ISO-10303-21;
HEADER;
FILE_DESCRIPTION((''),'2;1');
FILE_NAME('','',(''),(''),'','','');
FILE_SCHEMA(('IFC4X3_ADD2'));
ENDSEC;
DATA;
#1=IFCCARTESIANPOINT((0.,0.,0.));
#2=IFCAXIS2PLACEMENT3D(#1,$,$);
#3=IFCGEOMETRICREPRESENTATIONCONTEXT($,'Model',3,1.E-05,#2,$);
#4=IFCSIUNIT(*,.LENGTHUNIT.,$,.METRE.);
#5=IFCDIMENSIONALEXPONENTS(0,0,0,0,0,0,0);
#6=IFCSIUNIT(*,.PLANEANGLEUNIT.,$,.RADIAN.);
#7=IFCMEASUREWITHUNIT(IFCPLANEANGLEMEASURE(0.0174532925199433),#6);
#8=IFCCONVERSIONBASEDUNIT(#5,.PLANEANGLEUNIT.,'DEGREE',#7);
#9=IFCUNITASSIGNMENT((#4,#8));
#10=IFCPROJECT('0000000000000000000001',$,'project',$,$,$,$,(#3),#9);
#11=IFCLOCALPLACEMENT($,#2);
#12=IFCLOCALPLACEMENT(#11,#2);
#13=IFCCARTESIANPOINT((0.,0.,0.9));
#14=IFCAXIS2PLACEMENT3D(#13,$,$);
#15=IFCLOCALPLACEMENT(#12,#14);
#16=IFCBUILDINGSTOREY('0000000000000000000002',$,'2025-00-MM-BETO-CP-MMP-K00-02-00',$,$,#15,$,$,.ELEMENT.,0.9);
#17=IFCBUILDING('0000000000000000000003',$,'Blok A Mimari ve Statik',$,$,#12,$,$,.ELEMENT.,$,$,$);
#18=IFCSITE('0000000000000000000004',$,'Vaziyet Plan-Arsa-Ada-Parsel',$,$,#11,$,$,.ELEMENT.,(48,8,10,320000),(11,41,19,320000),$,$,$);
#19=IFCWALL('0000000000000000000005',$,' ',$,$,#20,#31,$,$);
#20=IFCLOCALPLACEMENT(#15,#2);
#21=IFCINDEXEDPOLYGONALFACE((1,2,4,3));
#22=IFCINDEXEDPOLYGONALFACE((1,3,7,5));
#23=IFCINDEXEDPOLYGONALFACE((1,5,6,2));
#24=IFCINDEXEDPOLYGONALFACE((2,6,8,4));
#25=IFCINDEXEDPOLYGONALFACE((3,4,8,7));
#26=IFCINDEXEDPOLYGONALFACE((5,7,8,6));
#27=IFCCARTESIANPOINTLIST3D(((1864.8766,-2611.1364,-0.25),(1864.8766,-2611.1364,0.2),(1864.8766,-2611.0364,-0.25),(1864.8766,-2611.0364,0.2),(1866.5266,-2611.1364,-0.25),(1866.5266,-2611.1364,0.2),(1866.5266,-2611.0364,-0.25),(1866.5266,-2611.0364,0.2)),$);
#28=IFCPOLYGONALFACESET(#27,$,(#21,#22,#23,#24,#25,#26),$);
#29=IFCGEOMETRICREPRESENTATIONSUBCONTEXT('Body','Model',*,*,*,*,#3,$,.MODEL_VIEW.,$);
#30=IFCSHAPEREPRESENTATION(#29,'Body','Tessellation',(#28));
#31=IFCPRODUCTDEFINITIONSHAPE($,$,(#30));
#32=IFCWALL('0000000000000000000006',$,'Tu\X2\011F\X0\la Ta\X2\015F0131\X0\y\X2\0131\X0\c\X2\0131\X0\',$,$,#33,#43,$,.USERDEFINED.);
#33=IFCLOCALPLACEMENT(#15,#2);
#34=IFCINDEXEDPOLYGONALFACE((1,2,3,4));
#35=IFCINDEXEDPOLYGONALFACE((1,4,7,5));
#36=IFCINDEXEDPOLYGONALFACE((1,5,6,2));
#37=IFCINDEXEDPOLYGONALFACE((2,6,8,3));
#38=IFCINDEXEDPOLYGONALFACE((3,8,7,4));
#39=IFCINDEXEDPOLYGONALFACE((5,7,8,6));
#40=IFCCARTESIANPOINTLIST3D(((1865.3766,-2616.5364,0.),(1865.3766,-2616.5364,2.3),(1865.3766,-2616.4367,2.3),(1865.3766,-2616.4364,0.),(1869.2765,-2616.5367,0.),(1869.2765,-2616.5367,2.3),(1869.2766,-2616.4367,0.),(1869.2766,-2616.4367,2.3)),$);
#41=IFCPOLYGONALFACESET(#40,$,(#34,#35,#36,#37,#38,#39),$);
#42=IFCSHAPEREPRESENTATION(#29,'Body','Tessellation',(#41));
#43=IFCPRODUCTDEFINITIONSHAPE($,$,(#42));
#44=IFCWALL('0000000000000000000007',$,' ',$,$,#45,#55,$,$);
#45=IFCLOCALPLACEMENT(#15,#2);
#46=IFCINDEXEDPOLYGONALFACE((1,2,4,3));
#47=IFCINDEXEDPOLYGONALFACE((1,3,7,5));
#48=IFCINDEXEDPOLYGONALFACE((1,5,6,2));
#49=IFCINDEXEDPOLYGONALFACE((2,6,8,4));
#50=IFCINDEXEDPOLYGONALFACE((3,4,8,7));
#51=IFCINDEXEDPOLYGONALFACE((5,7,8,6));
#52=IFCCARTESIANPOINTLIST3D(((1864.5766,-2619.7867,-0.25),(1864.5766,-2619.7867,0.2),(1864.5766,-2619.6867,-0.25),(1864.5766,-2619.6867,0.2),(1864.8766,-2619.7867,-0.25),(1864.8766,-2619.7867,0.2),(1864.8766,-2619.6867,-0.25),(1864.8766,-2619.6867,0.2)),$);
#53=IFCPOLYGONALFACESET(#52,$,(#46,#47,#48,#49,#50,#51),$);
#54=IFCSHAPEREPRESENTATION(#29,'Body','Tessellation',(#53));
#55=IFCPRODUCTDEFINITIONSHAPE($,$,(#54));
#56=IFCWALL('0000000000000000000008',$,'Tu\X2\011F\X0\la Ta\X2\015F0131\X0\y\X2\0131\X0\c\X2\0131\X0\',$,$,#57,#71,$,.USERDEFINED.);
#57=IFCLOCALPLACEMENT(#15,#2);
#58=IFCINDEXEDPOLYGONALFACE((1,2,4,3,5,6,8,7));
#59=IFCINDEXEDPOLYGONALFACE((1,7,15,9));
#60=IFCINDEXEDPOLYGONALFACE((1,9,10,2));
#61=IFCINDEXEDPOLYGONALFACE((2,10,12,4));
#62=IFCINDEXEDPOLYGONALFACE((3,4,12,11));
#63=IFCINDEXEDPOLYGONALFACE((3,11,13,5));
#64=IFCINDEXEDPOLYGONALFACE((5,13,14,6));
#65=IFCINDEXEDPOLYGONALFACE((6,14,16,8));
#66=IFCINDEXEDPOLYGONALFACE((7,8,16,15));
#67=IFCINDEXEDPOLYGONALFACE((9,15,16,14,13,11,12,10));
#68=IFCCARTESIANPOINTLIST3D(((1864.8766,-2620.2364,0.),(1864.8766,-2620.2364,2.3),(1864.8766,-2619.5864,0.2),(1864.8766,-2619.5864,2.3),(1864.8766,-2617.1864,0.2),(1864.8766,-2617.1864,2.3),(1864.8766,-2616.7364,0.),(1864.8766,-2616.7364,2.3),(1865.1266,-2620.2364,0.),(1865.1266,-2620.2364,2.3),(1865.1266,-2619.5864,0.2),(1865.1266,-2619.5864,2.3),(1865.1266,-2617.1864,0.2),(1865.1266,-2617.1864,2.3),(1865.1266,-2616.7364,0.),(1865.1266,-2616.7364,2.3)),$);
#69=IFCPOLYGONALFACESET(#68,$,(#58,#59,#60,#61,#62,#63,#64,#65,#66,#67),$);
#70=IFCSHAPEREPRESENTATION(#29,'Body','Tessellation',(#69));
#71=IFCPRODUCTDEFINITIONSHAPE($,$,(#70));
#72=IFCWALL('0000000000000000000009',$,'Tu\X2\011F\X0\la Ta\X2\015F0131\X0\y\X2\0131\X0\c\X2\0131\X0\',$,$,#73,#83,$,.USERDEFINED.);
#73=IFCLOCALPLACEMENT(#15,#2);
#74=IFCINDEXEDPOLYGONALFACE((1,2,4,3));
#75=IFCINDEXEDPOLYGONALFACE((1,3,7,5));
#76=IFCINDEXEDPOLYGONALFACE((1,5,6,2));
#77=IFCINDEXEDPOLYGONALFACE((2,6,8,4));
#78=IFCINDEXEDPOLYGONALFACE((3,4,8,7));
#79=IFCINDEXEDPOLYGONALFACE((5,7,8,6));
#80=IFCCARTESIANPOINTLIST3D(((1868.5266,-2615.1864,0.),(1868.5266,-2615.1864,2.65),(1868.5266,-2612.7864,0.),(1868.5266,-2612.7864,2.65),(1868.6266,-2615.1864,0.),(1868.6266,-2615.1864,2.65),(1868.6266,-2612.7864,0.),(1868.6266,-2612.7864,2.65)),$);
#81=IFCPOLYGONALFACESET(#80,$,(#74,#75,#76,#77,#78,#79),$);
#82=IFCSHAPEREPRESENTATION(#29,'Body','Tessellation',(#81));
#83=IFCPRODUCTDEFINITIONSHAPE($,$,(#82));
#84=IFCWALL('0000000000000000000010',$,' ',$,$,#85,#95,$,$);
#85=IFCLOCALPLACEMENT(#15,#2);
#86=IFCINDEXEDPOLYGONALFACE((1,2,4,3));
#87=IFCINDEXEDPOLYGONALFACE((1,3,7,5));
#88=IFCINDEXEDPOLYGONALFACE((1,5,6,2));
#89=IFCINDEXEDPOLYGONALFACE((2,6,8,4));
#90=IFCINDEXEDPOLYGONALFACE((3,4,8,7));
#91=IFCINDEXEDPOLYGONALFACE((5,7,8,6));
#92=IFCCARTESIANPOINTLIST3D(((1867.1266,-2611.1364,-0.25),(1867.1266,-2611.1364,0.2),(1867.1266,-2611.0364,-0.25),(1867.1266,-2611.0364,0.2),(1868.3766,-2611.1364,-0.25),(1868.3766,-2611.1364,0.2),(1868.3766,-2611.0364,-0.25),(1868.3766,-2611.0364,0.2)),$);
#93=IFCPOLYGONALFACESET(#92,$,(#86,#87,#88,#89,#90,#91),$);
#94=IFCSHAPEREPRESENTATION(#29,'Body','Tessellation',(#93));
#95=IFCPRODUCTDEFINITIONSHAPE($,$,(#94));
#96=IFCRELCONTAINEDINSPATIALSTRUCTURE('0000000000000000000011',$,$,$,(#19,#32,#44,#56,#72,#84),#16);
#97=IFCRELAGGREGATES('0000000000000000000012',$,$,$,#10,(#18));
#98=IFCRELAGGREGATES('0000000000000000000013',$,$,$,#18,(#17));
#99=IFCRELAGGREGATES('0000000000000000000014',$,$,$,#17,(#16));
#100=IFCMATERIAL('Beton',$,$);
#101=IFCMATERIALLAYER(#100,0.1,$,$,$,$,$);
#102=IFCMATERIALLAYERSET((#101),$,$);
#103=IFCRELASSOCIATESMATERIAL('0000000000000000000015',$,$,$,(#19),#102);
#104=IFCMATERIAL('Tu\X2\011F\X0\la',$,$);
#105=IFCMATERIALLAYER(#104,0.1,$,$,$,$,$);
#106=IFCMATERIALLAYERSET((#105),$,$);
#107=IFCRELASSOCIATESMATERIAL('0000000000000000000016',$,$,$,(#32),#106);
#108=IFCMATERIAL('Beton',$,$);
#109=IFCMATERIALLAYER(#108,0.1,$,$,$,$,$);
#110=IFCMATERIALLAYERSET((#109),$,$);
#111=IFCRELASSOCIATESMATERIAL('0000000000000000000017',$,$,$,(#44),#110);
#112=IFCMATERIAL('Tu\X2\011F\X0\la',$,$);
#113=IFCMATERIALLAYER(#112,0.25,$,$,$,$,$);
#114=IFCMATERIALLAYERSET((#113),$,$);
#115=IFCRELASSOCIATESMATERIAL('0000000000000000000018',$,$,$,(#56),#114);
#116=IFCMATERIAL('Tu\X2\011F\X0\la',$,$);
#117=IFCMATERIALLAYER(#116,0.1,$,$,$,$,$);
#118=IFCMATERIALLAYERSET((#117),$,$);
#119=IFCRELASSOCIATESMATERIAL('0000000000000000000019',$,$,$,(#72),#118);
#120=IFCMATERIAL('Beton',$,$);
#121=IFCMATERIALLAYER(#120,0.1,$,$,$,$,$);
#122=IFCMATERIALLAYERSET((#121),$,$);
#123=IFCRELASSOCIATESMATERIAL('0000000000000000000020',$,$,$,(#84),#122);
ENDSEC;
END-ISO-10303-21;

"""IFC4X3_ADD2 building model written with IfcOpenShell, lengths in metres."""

from ifc_helpers import new_model, entity, si_unit, converted_unit, frame, frame_2d, origin, origin_with_axes, place, context, subcontext, project, spatial, polyline, rectangle, outline, extrude, clip, bounded_halfspace, material, layer, layer_set, layer_usage, element, save


model = new_model("IFC4X3_ADD2")

# Units and contexts
model_context = context("Model", 3, precision=1e-05, world=origin())
body_context = subcontext(model_context, "Body", "Model", "MODEL_VIEW")
ifc_project = project(units=[si_unit("LENGTHUNIT", "METRE"), converted_unit("PLANEANGLEUNIT", "DEGREE", entity("IfcPlaneAngleMeasure", 0.0174532925199433), si_unit("PLANEANGLEUNIT", "RADIAN"), dimensions=[0, 0, 0, 0, 0, 0, 0])], contexts=[model_context])

# Site, building, storey
site_placement = place(None, origin())
site = spatial("IfcSite", under=ifc_project, at=site_placement, Name="Vaziyet Plan-Arsa-Ada-Parsel", CompositionType="ELEMENT", RefLatitude=(48, 8, 10, 320000), RefLongitude=(11, 41, 19, 320000))
building_placement = place(site_placement, origin())
building = spatial("IfcBuilding", under=site, at=building_placement, Name="Blok A Mimari ve Statik", CompositionType="ELEMENT")
storey_placement = place(building_placement, frame((0.0, 0.0, 0.9)))
storey = spatial("IfcBuildingStorey", under=building, at=storey_placement, Name="2025-00-MM-BETO-CP-MMP-K00-02-00", CompositionType="ELEMENT", Elevation=0.9)

# Walls
ifc_material_1 = material(Name="Beton")
ifc_layer_1 = layer(ifc_material_1, 0.1)
ifc_layer_set_1 = layer_set([ifc_layer_1])
ifc_layer_usage_1 = layer_usage(ifc_layer_set_1, "AXIS2", "POSITIVE", 0.0)
wall_1_placement = place(storey_placement, frame((1866.5266, -2611.0364, -0.25), z_axis=(0.0, 0.0, 1.0), x_axis=(-1.0, 0.0, 0.0)))
element("IfcWall", 1, at=wall_1_placement, inside=storey, material=ifc_layer_usage_1, Name=" ", context=body_context, shape_type="SweptSolid", body=[
    extrude(rectangle(XDim=1.65, YDim=0.1, at=frame_2d((0.825, 0.05), x_axis=(1.0, 0.0))), origin_with_axes(), (0.0, 0.0, 1.0), 0.45),
])
ifc_material_2 = material(Name="Tuğla")
ifc_layer_2 = layer(ifc_material_2, 0.1)
ifc_layer_set_2 = layer_set([ifc_layer_2])
ifc_layer_usage_2 = layer_usage(ifc_layer_set_2, "AXIS2", "POSITIVE", 0.0)
wall_2_placement = place(storey_placement, frame((1869.2766, -2616.4367, 0.0), z_axis=(0.0, 0.0, 1.0), x_axis=(-1.0, 0.000079, 0.0)))
element("IfcWall", 2, at=wall_2_placement, inside=storey, material=ifc_layer_usage_2, Name="Tuğla Taşıyıcı", PredefinedType="USERDEFINED", context=body_context, shape_type="Clipping", body=[
    clip(extrude(rectangle(XDim=3.9, YDim=0.1, at=frame_2d((1.95, 0.05), x_axis=(1.0, 0.0))), origin_with_axes(), (0.0, 0.0, 1.0), 2.65), bounded_halfspace(frame((1.95, 0.0501, 2.3), z_axis=(0.0, 0.0, -1.0), x_axis=(-1.0, 0.0, 0.0)), True, origin_with_axes(), polyline([(3.9, 0.1), (0.0, 0.1), (0.0, 0.0), (3.9, 0.0003), (3.9, 0.1)]))),
])
ifc_material_3 = material(Name="Beton")
ifc_layer_3 = layer(ifc_material_3, 0.1)
ifc_layer_set_3 = layer_set([ifc_layer_3])
ifc_layer_usage_3 = layer_usage(ifc_layer_set_3, "AXIS2", "POSITIVE", 0.0)
wall_3_placement = place(storey_placement, frame((1864.5766, -2619.7867, -0.25)))
element("IfcWall", 3, at=wall_3_placement, inside=storey, material=ifc_layer_usage_3, Name=" ", context=body_context, shape_type="SweptSolid", body=[
    extrude(rectangle(XDim=0.3, YDim=0.1, at=frame_2d((0.15, 0.05), x_axis=(1.0, 0.0))), origin_with_axes(), (0.0, 0.0, 1.0), 0.45),
])

# Wall, opening
ifc_material_4 = material(Name="Tuğla")
ifc_layer_4 = layer(ifc_material_4, 0.25)
ifc_layer_set_4 = layer_set([ifc_layer_4])
ifc_layer_usage_4 = layer_usage(ifc_layer_set_4, "AXIS2", "POSITIVE", 0.0)
wall_4_placement = place(storey_placement, frame((1864.8766, -2616.7364, 0.0), z_axis=(0.0, 0.0, 1.0), x_axis=(0.0, -1.0, 0.0)))
wall_4 = element("IfcWall", 4, at=wall_4_placement, inside=storey, material=ifc_layer_usage_4, Name="Tuğla Taşıyıcı", PredefinedType="USERDEFINED", context=body_context, shape_type="SweptSolid", body=[
    extrude(rectangle(XDim=3.5, YDim=0.25, at=frame_2d((1.75, 0.125), x_axis=(1.0, 0.0))), origin_with_axes(), (0.0, 0.0, 1.0), 2.3),
])
opening_1_placement = place(wall_4_placement, frame((0.45, 0.0, 0.2), z_axis=(0.0, 1.0, 0.0), x_axis=(0.0, 0.0, 1.0)))
element("IfcOpeningElement", 5, at=opening_1_placement, cuts=wall_4, PredefinedType="OPENING", context=body_context, shape_type="SweptSolid", body=[
    extrude(outline(polyline([(2.1, 2.4), (2.1, 0.0), (0.0, 0.0), (0.0, 2.4), (2.1, 2.4)])), origin_with_axes(), (0.0, 0.0, 1.0), 0.25),
])

# Walls
ifc_material_5 = material(Name="Tuğla")
ifc_layer_5 = layer(ifc_material_5, 0.1)
ifc_layer_set_5 = layer_set([ifc_layer_5])
ifc_layer_usage_5 = layer_usage(ifc_layer_set_5, "AXIS2", "POSITIVE", 0.0)
wall_5_placement = place(storey_placement, frame((1868.6266, -2615.1864, 0.0), z_axis=(0.0, 0.0, 1.0), x_axis=(0.0, 1.0, 0.0)))
element("IfcWall", 6, at=wall_5_placement, inside=storey, material=ifc_layer_usage_5, Name="Tuğla Taşıyıcı", PredefinedType="USERDEFINED", context=body_context, shape_type="SweptSolid", body=[
    extrude(rectangle(XDim=2.4, YDim=0.1, at=frame_2d((1.2, 0.05), x_axis=(1.0, 0.0))), origin_with_axes(), (0.0, 0.0, 1.0), 2.65),
])
ifc_material_6 = material(Name="Beton")
ifc_layer_6 = layer(ifc_material_6, 0.1)
ifc_layer_set_6 = layer_set([ifc_layer_6])
ifc_layer_usage_6 = layer_usage(ifc_layer_set_6, "AXIS2", "POSITIVE", 0.0)
wall_6_placement = place(storey_placement, frame((1868.3766, -2611.0364, -0.25), z_axis=(0.0, 0.0, 1.0), x_axis=(-1.0, 0.0, 0.0)))
element("IfcWall", 7, at=wall_6_placement, inside=storey, material=ifc_layer_usage_6, Name=" ", context=body_context, shape_type="SweptSolid", body=[
    extrude(rectangle(XDim=1.25, YDim=0.1, at=frame_2d((0.625, 0.05), x_axis=(1.0, 0.0))), origin_with_axes(), (0.0, 0.0, 1.0), 0.45),
])

save(model, "model.ifc")
